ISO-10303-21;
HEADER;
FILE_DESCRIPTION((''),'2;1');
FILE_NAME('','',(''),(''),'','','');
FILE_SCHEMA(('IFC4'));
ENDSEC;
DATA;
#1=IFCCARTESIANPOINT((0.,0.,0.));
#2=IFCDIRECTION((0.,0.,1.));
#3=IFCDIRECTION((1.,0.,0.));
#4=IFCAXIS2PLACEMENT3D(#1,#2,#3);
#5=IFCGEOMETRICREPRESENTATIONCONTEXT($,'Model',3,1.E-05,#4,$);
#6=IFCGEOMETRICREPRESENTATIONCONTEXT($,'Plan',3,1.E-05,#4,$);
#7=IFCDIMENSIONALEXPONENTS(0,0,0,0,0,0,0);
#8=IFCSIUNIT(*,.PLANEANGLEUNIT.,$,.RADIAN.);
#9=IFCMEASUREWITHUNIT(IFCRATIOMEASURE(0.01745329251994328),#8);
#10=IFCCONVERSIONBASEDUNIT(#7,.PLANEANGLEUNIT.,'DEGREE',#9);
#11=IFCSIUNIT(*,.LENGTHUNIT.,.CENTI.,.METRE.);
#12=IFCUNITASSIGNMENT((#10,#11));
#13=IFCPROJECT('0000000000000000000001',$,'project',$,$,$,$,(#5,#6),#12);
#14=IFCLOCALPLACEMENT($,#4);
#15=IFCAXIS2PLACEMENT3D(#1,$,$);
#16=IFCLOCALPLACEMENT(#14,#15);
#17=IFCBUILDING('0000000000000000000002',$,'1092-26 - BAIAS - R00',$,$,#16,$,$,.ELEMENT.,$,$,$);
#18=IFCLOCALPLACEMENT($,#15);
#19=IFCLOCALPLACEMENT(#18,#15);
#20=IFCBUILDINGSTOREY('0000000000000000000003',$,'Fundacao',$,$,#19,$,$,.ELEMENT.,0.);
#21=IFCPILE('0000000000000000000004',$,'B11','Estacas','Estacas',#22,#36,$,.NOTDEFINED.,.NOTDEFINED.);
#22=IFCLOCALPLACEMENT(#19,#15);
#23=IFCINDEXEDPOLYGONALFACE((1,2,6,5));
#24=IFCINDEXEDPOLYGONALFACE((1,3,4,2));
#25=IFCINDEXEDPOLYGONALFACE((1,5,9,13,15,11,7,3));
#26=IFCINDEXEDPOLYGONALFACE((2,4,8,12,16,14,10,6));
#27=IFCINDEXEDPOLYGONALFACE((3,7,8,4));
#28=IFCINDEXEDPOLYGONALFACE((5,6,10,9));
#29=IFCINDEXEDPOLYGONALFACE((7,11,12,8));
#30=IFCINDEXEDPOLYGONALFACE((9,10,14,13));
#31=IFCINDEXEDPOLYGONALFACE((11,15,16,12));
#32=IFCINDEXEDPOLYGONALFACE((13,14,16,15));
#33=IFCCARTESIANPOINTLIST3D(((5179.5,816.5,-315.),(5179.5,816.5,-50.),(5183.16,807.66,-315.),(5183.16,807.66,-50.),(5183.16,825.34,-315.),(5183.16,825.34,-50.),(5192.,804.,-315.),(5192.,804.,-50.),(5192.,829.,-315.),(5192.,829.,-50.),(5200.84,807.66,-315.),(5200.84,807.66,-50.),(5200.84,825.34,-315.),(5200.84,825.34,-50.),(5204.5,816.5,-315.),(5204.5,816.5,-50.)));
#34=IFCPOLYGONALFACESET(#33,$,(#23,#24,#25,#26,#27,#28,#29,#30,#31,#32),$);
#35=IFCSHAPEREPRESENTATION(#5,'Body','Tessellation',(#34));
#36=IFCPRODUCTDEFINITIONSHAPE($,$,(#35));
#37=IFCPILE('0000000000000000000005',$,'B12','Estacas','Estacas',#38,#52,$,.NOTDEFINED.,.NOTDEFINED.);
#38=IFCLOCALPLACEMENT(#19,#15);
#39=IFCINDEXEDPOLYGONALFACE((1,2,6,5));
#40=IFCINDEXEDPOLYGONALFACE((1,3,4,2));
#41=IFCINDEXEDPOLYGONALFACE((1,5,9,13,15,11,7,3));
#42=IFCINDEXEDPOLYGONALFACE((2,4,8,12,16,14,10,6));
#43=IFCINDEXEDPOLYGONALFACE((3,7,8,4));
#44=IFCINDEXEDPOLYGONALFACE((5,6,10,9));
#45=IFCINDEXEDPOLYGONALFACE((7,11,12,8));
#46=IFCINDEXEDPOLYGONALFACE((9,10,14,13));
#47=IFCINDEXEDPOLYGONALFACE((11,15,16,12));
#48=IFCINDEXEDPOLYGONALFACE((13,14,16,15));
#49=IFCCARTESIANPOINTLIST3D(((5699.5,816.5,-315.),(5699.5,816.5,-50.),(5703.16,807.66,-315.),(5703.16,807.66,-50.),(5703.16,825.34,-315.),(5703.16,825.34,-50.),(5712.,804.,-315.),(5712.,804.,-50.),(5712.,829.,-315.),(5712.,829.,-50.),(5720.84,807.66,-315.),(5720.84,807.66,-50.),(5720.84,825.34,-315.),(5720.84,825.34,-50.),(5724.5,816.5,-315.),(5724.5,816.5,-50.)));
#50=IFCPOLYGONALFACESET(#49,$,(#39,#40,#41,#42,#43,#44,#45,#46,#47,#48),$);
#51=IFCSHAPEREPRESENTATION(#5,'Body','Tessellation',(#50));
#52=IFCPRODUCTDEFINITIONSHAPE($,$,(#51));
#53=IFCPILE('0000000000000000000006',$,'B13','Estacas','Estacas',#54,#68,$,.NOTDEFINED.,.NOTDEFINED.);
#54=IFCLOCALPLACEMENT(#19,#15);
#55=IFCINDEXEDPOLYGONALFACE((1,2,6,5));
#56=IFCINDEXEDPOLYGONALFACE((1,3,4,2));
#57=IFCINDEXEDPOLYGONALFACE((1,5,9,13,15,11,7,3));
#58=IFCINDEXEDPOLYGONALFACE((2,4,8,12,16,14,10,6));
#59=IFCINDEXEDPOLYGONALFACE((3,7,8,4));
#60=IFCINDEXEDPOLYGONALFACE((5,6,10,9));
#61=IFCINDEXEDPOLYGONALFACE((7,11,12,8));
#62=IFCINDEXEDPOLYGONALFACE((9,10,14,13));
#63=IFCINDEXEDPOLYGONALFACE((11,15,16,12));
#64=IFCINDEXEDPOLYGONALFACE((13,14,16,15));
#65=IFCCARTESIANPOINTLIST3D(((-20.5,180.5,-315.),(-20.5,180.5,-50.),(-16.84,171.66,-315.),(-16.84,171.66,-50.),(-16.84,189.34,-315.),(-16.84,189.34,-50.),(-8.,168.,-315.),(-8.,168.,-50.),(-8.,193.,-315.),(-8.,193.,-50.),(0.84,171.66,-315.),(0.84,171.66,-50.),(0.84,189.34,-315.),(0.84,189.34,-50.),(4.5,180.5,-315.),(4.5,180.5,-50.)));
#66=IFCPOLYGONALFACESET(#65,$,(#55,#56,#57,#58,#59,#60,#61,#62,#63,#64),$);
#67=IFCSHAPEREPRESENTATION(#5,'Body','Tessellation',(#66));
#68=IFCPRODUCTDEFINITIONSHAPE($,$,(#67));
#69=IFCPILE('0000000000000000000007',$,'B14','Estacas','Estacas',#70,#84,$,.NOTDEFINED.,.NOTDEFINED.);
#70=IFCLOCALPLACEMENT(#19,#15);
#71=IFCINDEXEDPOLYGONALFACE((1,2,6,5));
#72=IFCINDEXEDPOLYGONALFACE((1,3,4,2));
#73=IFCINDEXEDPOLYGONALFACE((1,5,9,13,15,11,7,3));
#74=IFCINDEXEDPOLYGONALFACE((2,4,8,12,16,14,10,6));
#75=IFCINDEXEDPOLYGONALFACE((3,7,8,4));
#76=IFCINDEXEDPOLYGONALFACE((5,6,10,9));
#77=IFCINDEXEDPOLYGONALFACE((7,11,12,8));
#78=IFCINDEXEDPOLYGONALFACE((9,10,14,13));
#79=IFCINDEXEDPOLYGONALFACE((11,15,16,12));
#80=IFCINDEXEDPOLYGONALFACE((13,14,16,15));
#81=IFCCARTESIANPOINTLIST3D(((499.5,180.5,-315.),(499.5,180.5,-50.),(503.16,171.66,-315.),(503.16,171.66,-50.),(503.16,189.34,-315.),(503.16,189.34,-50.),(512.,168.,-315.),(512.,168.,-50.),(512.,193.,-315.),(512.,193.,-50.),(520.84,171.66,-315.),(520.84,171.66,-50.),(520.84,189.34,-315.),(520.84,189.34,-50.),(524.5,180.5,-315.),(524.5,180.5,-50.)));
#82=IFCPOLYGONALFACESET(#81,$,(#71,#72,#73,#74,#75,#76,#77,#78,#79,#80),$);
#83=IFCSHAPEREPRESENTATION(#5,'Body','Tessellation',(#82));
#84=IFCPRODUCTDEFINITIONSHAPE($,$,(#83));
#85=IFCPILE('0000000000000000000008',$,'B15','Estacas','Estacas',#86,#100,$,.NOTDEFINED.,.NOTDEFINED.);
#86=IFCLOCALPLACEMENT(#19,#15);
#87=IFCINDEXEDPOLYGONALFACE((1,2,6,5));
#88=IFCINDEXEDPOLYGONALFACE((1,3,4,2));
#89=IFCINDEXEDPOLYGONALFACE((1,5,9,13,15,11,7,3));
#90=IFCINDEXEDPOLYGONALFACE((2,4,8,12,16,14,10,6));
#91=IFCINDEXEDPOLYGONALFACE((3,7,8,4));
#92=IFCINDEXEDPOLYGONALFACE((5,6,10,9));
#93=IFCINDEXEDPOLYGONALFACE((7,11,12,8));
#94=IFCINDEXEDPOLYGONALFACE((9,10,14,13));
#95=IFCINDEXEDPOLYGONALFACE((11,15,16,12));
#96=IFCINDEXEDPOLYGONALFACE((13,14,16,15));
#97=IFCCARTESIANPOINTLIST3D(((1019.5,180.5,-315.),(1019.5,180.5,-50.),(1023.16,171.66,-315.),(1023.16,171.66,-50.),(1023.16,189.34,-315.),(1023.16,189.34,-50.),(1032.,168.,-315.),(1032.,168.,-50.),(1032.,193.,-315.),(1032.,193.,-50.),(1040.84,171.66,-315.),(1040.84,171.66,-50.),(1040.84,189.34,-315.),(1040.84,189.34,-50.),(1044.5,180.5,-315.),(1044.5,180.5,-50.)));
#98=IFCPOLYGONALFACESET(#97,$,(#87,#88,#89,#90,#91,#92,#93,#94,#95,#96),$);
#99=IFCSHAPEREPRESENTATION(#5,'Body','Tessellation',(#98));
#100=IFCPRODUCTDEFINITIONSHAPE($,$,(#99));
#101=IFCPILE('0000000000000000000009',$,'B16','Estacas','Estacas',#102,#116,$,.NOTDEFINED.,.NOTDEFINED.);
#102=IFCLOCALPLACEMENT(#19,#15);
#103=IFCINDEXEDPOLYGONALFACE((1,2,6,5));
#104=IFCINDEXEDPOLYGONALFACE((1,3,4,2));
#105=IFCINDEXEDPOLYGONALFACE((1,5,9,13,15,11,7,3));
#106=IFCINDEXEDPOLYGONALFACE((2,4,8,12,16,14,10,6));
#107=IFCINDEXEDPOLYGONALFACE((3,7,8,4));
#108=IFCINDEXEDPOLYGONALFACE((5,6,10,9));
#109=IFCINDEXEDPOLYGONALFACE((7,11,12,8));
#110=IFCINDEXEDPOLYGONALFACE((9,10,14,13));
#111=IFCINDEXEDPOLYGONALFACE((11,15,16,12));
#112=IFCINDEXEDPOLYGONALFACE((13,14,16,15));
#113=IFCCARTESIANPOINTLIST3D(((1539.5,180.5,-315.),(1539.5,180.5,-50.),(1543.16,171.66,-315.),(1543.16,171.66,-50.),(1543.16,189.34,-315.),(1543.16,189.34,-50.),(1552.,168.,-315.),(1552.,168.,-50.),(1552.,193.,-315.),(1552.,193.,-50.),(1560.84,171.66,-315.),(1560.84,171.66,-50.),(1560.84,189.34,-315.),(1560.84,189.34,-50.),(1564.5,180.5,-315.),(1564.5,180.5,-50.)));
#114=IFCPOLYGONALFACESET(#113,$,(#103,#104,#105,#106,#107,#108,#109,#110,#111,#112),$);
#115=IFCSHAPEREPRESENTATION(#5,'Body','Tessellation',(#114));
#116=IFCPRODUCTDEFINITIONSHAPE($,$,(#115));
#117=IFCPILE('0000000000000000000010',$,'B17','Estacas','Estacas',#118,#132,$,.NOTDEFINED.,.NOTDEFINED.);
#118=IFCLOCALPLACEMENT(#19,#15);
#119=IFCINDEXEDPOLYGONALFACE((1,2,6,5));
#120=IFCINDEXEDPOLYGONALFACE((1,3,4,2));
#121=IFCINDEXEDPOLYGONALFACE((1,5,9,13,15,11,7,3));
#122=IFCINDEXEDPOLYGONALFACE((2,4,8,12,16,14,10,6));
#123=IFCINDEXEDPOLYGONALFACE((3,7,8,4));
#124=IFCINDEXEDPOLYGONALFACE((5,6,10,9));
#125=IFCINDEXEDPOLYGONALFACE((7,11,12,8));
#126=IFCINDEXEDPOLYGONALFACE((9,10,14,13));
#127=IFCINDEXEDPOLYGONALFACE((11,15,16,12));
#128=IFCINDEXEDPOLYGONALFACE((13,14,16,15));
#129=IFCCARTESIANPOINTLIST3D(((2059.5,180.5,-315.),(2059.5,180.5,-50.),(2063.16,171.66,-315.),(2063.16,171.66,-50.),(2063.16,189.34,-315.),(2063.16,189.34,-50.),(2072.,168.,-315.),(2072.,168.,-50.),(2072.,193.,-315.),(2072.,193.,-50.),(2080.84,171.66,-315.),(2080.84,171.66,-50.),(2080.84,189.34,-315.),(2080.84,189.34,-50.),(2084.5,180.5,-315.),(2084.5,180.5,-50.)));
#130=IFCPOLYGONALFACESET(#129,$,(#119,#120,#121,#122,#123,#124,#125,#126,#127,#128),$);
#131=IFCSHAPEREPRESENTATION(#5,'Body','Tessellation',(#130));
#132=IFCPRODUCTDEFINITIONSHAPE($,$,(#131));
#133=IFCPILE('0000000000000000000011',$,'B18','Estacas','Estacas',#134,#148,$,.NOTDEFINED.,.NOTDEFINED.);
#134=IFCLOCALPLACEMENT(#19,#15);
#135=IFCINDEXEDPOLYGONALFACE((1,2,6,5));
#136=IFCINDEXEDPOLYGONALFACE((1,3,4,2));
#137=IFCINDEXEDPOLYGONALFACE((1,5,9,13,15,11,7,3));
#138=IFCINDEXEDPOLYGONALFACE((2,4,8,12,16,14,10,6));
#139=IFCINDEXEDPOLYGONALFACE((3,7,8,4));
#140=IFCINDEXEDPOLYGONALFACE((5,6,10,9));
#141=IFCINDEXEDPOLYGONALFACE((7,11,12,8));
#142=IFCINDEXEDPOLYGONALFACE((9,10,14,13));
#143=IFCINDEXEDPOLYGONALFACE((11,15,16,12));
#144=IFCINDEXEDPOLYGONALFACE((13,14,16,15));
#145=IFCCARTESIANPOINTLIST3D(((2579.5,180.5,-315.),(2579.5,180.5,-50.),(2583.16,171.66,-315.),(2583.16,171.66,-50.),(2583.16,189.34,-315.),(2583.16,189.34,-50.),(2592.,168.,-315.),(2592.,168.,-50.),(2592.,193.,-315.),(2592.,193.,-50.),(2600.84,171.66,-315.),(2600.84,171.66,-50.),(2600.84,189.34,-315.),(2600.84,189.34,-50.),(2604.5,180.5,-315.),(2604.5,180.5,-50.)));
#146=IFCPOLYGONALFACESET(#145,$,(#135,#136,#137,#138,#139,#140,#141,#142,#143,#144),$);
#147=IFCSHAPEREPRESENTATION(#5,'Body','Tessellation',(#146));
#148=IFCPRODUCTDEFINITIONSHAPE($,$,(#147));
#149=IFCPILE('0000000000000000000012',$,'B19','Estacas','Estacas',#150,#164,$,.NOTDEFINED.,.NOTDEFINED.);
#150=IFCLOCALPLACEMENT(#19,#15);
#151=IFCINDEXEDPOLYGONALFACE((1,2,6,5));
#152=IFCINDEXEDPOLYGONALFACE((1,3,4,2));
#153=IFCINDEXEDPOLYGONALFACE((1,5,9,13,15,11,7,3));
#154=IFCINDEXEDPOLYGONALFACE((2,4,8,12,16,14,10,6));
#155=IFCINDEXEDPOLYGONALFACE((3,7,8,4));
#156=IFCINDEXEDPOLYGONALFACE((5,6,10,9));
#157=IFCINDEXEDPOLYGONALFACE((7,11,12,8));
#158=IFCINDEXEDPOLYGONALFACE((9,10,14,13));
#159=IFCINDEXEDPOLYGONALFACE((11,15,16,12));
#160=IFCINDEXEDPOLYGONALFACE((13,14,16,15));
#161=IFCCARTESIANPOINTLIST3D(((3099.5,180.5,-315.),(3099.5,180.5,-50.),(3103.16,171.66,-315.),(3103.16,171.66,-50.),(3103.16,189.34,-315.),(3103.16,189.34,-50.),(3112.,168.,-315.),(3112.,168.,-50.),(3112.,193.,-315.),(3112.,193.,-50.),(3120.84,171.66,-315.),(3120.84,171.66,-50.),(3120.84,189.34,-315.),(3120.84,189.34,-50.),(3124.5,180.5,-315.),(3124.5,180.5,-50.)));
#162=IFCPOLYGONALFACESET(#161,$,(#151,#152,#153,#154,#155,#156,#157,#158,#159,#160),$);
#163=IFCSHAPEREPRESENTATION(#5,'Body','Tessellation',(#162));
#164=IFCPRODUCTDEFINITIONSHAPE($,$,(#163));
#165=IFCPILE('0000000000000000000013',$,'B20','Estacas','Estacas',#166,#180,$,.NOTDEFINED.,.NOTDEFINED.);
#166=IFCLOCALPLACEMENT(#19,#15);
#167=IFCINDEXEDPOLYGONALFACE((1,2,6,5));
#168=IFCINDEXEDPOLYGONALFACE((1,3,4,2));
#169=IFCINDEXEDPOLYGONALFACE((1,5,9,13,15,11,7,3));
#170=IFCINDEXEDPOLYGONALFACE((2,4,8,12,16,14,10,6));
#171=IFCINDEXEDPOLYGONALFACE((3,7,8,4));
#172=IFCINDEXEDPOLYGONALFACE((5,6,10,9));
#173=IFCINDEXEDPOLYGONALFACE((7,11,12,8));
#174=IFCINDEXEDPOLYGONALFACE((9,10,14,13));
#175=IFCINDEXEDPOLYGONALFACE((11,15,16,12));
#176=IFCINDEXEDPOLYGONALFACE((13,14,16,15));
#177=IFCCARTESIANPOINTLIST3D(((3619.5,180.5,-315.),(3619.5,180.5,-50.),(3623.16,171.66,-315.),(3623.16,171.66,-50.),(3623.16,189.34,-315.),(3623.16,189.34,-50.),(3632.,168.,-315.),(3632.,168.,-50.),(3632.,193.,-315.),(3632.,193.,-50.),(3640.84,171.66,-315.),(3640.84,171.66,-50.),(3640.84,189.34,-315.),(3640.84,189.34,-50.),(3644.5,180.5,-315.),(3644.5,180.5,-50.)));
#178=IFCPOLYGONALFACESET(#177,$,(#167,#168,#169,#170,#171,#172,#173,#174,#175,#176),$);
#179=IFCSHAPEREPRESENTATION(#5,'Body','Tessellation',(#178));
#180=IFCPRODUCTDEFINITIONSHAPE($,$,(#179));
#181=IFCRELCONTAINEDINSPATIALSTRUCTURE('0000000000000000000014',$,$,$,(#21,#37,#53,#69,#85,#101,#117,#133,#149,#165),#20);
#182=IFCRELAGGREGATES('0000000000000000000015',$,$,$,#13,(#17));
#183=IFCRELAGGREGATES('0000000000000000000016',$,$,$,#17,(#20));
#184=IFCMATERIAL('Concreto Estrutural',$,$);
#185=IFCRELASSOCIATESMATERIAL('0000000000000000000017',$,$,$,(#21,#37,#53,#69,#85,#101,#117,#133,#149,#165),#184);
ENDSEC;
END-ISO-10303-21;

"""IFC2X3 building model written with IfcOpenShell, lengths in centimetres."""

from ifc_helpers import new_model, entity, si_unit, converted_unit, frame, origin, origin_with_axes, place, context, project, spatial, polyline, outline, extrude, material, element, save


model = new_model("IFC2X3")

# Units and contexts
model_context = context("Model", 3, precision=1e-05, world=origin_with_axes())
plan_context = context("Plan", 3, precision=1e-05, world=origin_with_axes())
ifc_project = project(units=[converted_unit("PLANEANGLEUNIT", "DEGREE", entity("IfcRatioMeasure", 0.01745329251994328), si_unit("PLANEANGLEUNIT", "RADIAN"), dimensions=[0, 0, 0, 0, 0, 0, 0]), si_unit("LENGTHUNIT", "METRE", prefix="CENTI")], contexts=[model_context, plan_context])

# Building, storey
placement_1 = place(None, origin_with_axes())
building_placement = place(placement_1, origin())
building = spatial("IfcBuilding", under=ifc_project, at=building_placement, Name="1092-26 - BAIAS - R00", CompositionType="ELEMENT")
placement_2 = place(None, origin())
storey_placement = place(placement_2, origin())
storey = spatial("IfcBuildingStorey", under=building, at=storey_placement, Name="Fundacao", CompositionType="ELEMENT", Elevation=0.0)

# Piles
ifc_material_1 = material(Name="Concreto Estrutural")
placement_3 = place(None, origin_with_axes())
placement_4 = place(placement_3, origin_with_axes())
placement_5 = place(placement_4, origin_with_axes())
pile_1_placement = place(placement_5, frame((5192.0, 816.5, -315.0), z_axis=(0.0, 0.0, 1.0), x_axis=(1.0, 0.0, 0.0)))
element("IfcPile", 1, at=pile_1_placement, inside=storey, material=ifc_material_1, Name="B11", Description="Estacas", ObjectType="Estacas", ConstructionType="NOTDEFINED", PredefinedType="NOTDEFINED", context=model_context, shape_type="SweptSolid", body=[
    extrude(outline(polyline([(8.84, -8.84, 0.0), (0.0, -12.5, 0.0), (-8.84, -8.84, 0.0), (-12.5, 0.0, 0.0), (-8.84, 8.84, 0.0), (0.0, 12.5, 0.0), (8.84, 8.84, 0.0), (12.5, 0.0, 0.0), (8.84, -8.84, 0.0)])), origin_with_axes(), (0.0, 0.0, 1.0), 265.0),
])
placement_6 = place(placement_4, origin_with_axes())
pile_2_placement = place(placement_6, frame((5712.0, 816.5, -315.0), z_axis=(0.0, 0.0, 1.0), x_axis=(1.0, 0.0, 0.0)))
element("IfcPile", 2, at=pile_2_placement, inside=storey, material=ifc_material_1, Name="B12", Description="Estacas", ObjectType="Estacas", ConstructionType="NOTDEFINED", PredefinedType="NOTDEFINED", context=model_context, shape_type="SweptSolid", body=[
    extrude(outline(polyline([(8.84, -8.84, 0.0), (0.0, -12.5, 0.0), (-8.84, -8.84, 0.0), (-12.5, 0.0, 0.0), (-8.84, 8.84, 0.0), (0.0, 12.5, 0.0), (8.84, 8.84, 0.0), (12.5, 0.0, 0.0), (8.84, -8.84, 0.0)])), origin_with_axes(), (0.0, 0.0, 1.0), 265.0),
])
placement_7 = place(placement_4, origin_with_axes())
pile_3_placement = place(placement_7, frame((-8.0, 180.5, -315.0), z_axis=(0.0, 0.0, 1.0), x_axis=(1.0, 0.0, 0.0)))
element("IfcPile", 3, at=pile_3_placement, inside=storey, material=ifc_material_1, Name="B13", Description="Estacas", ObjectType="Estacas", ConstructionType="NOTDEFINED", PredefinedType="NOTDEFINED", context=model_context, shape_type="SweptSolid", body=[
    extrude(outline(polyline([(8.84, -8.84, 0.0), (0.0, -12.5, 0.0), (-8.84, -8.84, 0.0), (-12.5, 0.0, 0.0), (-8.84, 8.84, 0.0), (0.0, 12.5, 0.0), (8.84, 8.84, 0.0), (12.5, 0.0, 0.0), (8.84, -8.84, 0.0)])), origin_with_axes(), (0.0, 0.0, 1.0), 265.0),
])
placement_8 = place(placement_4, origin_with_axes())
pile_4_placement = place(placement_8, frame((512.0, 180.5, -315.0), z_axis=(0.0, 0.0, 1.0), x_axis=(1.0, 0.0, 0.0)))
element("IfcPile", 4, at=pile_4_placement, inside=storey, material=ifc_material_1, Name="B14", Description="Estacas", ObjectType="Estacas", ConstructionType="NOTDEFINED", PredefinedType="NOTDEFINED", context=model_context, shape_type="SweptSolid", body=[
    extrude(outline(polyline([(8.84, -8.84, 0.0), (0.0, -12.5, 0.0), (-8.84, -8.84, 0.0), (-12.5, 0.0, 0.0), (-8.84, 8.84, 0.0), (0.0, 12.5, 0.0), (8.84, 8.84, 0.0), (12.5, 0.0, 0.0), (8.84, -8.84, 0.0)])), origin_with_axes(), (0.0, 0.0, 1.0), 265.0),
])
placement_9 = place(placement_4, origin_with_axes())
pile_5_placement = place(placement_9, frame((1032.0, 180.5, -315.0), z_axis=(0.0, 0.0, 1.0), x_axis=(1.0, 0.0, 0.0)))
element("IfcPile", 5, at=pile_5_placement, inside=storey, material=ifc_material_1, Name="B15", Description="Estacas", ObjectType="Estacas", ConstructionType="NOTDEFINED", PredefinedType="NOTDEFINED", context=model_context, shape_type="SweptSolid", body=[
    extrude(outline(polyline([(8.84, -8.84, 0.0), (0.0, -12.5, 0.0), (-8.84, -8.84, 0.0), (-12.5, 0.0, 0.0), (-8.84, 8.84, 0.0), (0.0, 12.5, 0.0), (8.84, 8.84, 0.0), (12.5, 0.0, 0.0), (8.84, -8.84, 0.0)])), origin_with_axes(), (0.0, 0.0, 1.0), 265.0),
])
placement_10 = place(placement_4, origin_with_axes())
pile_6_placement = place(placement_10, frame((1552.0, 180.5, -315.0), z_axis=(0.0, 0.0, 1.0), x_axis=(1.0, 0.0, 0.0)))
element("IfcPile", 6, at=pile_6_placement, inside=storey, material=ifc_material_1, Name="B16", Description="Estacas", ObjectType="Estacas", ConstructionType="NOTDEFINED", PredefinedType="NOTDEFINED", context=model_context, shape_type="SweptSolid", body=[
    extrude(outline(polyline([(8.84, -8.84, 0.0), (0.0, -12.5, 0.0), (-8.84, -8.84, 0.0), (-12.5, 0.0, 0.0), (-8.84, 8.84, 0.0), (0.0, 12.5, 0.0), (8.84, 8.84, 0.0), (12.5, 0.0, 0.0), (8.84, -8.84, 0.0)])), origin_with_axes(), (0.0, 0.0, 1.0), 265.0),
])
placement_11 = place(placement_4, origin_with_axes())
pile_7_placement = place(placement_11, frame((2072.0, 180.5, -315.0), z_axis=(0.0, 0.0, 1.0), x_axis=(1.0, 0.0, 0.0)))
element("IfcPile", 7, at=pile_7_placement, inside=storey, material=ifc_material_1, Name="B17", Description="Estacas", ObjectType="Estacas", ConstructionType="NOTDEFINED", PredefinedType="NOTDEFINED", context=model_context, shape_type="SweptSolid", body=[
    extrude(outline(polyline([(8.84, -8.84, 0.0), (0.0, -12.5, 0.0), (-8.84, -8.84, 0.0), (-12.5, 0.0, 0.0), (-8.84, 8.84, 0.0), (0.0, 12.5, 0.0), (8.84, 8.84, 0.0), (12.5, 0.0, 0.0), (8.84, -8.84, 0.0)])), origin_with_axes(), (0.0, 0.0, 1.0), 265.0),
])
placement_12 = place(placement_4, origin_with_axes())
pile_8_placement = place(placement_12, frame((2592.0, 180.5, -315.0), z_axis=(0.0, 0.0, 1.0), x_axis=(1.0, 0.0, 0.0)))
element("IfcPile", 8, at=pile_8_placement, inside=storey, material=ifc_material_1, Name="B18", Description="Estacas", ObjectType="Estacas", ConstructionType="NOTDEFINED", PredefinedType="NOTDEFINED", context=model_context, shape_type="SweptSolid", body=[
    extrude(outline(polyline([(8.84, -8.84, 0.0), (0.0, -12.5, 0.0), (-8.84, -8.84, 0.0), (-12.5, 0.0, 0.0), (-8.84, 8.84, 0.0), (0.0, 12.5, 0.0), (8.84, 8.84, 0.0), (12.5, 0.0, 0.0), (8.84, -8.84, 0.0)])), origin_with_axes(), (0.0, 0.0, 1.0), 265.0),
])
placement_13 = place(placement_4, origin_with_axes())
pile_9_placement = place(placement_13, frame((3112.0, 180.5, -315.0), z_axis=(0.0, 0.0, 1.0), x_axis=(1.0, 0.0, 0.0)))
element("IfcPile", 9, at=pile_9_placement, inside=storey, material=ifc_material_1, Name="B19", Description="Estacas", ObjectType="Estacas", ConstructionType="NOTDEFINED", PredefinedType="NOTDEFINED", context=model_context, shape_type="SweptSolid", body=[
    extrude(outline(polyline([(8.84, -8.84, 0.0), (0.0, -12.5, 0.0), (-8.84, -8.84, 0.0), (-12.5, 0.0, 0.0), (-8.84, 8.84, 0.0), (0.0, 12.5, 0.0), (8.84, 8.84, 0.0), (12.5, 0.0, 0.0), (8.84, -8.84, 0.0)])), origin_with_axes(), (0.0, 0.0, 1.0), 265.0),
])
placement_14 = place(placement_4, origin_with_axes())
pile_10_placement = place(placement_14, frame((3632.0, 180.5, -315.0), z_axis=(0.0, 0.0, 1.0), x_axis=(1.0, 0.0, 0.0)))
element("IfcPile", 10, at=pile_10_placement, inside=storey, material=ifc_material_1, Name="B20", Description="Estacas", ObjectType="Estacas", ConstructionType="NOTDEFINED", PredefinedType="NOTDEFINED", context=model_context, shape_type="SweptSolid", body=[
    extrude(outline(polyline([(8.84, -8.84, 0.0), (0.0, -12.5, 0.0), (-8.84, -8.84, 0.0), (-12.5, 0.0, 0.0), (-8.84, 8.84, 0.0), (0.0, 12.5, 0.0), (8.84, 8.84, 0.0), (12.5, 0.0, 0.0), (8.84, -8.84, 0.0)])), origin_with_axes(), (0.0, 0.0, 1.0), 265.0),
])

save(model, "model.ifc")
